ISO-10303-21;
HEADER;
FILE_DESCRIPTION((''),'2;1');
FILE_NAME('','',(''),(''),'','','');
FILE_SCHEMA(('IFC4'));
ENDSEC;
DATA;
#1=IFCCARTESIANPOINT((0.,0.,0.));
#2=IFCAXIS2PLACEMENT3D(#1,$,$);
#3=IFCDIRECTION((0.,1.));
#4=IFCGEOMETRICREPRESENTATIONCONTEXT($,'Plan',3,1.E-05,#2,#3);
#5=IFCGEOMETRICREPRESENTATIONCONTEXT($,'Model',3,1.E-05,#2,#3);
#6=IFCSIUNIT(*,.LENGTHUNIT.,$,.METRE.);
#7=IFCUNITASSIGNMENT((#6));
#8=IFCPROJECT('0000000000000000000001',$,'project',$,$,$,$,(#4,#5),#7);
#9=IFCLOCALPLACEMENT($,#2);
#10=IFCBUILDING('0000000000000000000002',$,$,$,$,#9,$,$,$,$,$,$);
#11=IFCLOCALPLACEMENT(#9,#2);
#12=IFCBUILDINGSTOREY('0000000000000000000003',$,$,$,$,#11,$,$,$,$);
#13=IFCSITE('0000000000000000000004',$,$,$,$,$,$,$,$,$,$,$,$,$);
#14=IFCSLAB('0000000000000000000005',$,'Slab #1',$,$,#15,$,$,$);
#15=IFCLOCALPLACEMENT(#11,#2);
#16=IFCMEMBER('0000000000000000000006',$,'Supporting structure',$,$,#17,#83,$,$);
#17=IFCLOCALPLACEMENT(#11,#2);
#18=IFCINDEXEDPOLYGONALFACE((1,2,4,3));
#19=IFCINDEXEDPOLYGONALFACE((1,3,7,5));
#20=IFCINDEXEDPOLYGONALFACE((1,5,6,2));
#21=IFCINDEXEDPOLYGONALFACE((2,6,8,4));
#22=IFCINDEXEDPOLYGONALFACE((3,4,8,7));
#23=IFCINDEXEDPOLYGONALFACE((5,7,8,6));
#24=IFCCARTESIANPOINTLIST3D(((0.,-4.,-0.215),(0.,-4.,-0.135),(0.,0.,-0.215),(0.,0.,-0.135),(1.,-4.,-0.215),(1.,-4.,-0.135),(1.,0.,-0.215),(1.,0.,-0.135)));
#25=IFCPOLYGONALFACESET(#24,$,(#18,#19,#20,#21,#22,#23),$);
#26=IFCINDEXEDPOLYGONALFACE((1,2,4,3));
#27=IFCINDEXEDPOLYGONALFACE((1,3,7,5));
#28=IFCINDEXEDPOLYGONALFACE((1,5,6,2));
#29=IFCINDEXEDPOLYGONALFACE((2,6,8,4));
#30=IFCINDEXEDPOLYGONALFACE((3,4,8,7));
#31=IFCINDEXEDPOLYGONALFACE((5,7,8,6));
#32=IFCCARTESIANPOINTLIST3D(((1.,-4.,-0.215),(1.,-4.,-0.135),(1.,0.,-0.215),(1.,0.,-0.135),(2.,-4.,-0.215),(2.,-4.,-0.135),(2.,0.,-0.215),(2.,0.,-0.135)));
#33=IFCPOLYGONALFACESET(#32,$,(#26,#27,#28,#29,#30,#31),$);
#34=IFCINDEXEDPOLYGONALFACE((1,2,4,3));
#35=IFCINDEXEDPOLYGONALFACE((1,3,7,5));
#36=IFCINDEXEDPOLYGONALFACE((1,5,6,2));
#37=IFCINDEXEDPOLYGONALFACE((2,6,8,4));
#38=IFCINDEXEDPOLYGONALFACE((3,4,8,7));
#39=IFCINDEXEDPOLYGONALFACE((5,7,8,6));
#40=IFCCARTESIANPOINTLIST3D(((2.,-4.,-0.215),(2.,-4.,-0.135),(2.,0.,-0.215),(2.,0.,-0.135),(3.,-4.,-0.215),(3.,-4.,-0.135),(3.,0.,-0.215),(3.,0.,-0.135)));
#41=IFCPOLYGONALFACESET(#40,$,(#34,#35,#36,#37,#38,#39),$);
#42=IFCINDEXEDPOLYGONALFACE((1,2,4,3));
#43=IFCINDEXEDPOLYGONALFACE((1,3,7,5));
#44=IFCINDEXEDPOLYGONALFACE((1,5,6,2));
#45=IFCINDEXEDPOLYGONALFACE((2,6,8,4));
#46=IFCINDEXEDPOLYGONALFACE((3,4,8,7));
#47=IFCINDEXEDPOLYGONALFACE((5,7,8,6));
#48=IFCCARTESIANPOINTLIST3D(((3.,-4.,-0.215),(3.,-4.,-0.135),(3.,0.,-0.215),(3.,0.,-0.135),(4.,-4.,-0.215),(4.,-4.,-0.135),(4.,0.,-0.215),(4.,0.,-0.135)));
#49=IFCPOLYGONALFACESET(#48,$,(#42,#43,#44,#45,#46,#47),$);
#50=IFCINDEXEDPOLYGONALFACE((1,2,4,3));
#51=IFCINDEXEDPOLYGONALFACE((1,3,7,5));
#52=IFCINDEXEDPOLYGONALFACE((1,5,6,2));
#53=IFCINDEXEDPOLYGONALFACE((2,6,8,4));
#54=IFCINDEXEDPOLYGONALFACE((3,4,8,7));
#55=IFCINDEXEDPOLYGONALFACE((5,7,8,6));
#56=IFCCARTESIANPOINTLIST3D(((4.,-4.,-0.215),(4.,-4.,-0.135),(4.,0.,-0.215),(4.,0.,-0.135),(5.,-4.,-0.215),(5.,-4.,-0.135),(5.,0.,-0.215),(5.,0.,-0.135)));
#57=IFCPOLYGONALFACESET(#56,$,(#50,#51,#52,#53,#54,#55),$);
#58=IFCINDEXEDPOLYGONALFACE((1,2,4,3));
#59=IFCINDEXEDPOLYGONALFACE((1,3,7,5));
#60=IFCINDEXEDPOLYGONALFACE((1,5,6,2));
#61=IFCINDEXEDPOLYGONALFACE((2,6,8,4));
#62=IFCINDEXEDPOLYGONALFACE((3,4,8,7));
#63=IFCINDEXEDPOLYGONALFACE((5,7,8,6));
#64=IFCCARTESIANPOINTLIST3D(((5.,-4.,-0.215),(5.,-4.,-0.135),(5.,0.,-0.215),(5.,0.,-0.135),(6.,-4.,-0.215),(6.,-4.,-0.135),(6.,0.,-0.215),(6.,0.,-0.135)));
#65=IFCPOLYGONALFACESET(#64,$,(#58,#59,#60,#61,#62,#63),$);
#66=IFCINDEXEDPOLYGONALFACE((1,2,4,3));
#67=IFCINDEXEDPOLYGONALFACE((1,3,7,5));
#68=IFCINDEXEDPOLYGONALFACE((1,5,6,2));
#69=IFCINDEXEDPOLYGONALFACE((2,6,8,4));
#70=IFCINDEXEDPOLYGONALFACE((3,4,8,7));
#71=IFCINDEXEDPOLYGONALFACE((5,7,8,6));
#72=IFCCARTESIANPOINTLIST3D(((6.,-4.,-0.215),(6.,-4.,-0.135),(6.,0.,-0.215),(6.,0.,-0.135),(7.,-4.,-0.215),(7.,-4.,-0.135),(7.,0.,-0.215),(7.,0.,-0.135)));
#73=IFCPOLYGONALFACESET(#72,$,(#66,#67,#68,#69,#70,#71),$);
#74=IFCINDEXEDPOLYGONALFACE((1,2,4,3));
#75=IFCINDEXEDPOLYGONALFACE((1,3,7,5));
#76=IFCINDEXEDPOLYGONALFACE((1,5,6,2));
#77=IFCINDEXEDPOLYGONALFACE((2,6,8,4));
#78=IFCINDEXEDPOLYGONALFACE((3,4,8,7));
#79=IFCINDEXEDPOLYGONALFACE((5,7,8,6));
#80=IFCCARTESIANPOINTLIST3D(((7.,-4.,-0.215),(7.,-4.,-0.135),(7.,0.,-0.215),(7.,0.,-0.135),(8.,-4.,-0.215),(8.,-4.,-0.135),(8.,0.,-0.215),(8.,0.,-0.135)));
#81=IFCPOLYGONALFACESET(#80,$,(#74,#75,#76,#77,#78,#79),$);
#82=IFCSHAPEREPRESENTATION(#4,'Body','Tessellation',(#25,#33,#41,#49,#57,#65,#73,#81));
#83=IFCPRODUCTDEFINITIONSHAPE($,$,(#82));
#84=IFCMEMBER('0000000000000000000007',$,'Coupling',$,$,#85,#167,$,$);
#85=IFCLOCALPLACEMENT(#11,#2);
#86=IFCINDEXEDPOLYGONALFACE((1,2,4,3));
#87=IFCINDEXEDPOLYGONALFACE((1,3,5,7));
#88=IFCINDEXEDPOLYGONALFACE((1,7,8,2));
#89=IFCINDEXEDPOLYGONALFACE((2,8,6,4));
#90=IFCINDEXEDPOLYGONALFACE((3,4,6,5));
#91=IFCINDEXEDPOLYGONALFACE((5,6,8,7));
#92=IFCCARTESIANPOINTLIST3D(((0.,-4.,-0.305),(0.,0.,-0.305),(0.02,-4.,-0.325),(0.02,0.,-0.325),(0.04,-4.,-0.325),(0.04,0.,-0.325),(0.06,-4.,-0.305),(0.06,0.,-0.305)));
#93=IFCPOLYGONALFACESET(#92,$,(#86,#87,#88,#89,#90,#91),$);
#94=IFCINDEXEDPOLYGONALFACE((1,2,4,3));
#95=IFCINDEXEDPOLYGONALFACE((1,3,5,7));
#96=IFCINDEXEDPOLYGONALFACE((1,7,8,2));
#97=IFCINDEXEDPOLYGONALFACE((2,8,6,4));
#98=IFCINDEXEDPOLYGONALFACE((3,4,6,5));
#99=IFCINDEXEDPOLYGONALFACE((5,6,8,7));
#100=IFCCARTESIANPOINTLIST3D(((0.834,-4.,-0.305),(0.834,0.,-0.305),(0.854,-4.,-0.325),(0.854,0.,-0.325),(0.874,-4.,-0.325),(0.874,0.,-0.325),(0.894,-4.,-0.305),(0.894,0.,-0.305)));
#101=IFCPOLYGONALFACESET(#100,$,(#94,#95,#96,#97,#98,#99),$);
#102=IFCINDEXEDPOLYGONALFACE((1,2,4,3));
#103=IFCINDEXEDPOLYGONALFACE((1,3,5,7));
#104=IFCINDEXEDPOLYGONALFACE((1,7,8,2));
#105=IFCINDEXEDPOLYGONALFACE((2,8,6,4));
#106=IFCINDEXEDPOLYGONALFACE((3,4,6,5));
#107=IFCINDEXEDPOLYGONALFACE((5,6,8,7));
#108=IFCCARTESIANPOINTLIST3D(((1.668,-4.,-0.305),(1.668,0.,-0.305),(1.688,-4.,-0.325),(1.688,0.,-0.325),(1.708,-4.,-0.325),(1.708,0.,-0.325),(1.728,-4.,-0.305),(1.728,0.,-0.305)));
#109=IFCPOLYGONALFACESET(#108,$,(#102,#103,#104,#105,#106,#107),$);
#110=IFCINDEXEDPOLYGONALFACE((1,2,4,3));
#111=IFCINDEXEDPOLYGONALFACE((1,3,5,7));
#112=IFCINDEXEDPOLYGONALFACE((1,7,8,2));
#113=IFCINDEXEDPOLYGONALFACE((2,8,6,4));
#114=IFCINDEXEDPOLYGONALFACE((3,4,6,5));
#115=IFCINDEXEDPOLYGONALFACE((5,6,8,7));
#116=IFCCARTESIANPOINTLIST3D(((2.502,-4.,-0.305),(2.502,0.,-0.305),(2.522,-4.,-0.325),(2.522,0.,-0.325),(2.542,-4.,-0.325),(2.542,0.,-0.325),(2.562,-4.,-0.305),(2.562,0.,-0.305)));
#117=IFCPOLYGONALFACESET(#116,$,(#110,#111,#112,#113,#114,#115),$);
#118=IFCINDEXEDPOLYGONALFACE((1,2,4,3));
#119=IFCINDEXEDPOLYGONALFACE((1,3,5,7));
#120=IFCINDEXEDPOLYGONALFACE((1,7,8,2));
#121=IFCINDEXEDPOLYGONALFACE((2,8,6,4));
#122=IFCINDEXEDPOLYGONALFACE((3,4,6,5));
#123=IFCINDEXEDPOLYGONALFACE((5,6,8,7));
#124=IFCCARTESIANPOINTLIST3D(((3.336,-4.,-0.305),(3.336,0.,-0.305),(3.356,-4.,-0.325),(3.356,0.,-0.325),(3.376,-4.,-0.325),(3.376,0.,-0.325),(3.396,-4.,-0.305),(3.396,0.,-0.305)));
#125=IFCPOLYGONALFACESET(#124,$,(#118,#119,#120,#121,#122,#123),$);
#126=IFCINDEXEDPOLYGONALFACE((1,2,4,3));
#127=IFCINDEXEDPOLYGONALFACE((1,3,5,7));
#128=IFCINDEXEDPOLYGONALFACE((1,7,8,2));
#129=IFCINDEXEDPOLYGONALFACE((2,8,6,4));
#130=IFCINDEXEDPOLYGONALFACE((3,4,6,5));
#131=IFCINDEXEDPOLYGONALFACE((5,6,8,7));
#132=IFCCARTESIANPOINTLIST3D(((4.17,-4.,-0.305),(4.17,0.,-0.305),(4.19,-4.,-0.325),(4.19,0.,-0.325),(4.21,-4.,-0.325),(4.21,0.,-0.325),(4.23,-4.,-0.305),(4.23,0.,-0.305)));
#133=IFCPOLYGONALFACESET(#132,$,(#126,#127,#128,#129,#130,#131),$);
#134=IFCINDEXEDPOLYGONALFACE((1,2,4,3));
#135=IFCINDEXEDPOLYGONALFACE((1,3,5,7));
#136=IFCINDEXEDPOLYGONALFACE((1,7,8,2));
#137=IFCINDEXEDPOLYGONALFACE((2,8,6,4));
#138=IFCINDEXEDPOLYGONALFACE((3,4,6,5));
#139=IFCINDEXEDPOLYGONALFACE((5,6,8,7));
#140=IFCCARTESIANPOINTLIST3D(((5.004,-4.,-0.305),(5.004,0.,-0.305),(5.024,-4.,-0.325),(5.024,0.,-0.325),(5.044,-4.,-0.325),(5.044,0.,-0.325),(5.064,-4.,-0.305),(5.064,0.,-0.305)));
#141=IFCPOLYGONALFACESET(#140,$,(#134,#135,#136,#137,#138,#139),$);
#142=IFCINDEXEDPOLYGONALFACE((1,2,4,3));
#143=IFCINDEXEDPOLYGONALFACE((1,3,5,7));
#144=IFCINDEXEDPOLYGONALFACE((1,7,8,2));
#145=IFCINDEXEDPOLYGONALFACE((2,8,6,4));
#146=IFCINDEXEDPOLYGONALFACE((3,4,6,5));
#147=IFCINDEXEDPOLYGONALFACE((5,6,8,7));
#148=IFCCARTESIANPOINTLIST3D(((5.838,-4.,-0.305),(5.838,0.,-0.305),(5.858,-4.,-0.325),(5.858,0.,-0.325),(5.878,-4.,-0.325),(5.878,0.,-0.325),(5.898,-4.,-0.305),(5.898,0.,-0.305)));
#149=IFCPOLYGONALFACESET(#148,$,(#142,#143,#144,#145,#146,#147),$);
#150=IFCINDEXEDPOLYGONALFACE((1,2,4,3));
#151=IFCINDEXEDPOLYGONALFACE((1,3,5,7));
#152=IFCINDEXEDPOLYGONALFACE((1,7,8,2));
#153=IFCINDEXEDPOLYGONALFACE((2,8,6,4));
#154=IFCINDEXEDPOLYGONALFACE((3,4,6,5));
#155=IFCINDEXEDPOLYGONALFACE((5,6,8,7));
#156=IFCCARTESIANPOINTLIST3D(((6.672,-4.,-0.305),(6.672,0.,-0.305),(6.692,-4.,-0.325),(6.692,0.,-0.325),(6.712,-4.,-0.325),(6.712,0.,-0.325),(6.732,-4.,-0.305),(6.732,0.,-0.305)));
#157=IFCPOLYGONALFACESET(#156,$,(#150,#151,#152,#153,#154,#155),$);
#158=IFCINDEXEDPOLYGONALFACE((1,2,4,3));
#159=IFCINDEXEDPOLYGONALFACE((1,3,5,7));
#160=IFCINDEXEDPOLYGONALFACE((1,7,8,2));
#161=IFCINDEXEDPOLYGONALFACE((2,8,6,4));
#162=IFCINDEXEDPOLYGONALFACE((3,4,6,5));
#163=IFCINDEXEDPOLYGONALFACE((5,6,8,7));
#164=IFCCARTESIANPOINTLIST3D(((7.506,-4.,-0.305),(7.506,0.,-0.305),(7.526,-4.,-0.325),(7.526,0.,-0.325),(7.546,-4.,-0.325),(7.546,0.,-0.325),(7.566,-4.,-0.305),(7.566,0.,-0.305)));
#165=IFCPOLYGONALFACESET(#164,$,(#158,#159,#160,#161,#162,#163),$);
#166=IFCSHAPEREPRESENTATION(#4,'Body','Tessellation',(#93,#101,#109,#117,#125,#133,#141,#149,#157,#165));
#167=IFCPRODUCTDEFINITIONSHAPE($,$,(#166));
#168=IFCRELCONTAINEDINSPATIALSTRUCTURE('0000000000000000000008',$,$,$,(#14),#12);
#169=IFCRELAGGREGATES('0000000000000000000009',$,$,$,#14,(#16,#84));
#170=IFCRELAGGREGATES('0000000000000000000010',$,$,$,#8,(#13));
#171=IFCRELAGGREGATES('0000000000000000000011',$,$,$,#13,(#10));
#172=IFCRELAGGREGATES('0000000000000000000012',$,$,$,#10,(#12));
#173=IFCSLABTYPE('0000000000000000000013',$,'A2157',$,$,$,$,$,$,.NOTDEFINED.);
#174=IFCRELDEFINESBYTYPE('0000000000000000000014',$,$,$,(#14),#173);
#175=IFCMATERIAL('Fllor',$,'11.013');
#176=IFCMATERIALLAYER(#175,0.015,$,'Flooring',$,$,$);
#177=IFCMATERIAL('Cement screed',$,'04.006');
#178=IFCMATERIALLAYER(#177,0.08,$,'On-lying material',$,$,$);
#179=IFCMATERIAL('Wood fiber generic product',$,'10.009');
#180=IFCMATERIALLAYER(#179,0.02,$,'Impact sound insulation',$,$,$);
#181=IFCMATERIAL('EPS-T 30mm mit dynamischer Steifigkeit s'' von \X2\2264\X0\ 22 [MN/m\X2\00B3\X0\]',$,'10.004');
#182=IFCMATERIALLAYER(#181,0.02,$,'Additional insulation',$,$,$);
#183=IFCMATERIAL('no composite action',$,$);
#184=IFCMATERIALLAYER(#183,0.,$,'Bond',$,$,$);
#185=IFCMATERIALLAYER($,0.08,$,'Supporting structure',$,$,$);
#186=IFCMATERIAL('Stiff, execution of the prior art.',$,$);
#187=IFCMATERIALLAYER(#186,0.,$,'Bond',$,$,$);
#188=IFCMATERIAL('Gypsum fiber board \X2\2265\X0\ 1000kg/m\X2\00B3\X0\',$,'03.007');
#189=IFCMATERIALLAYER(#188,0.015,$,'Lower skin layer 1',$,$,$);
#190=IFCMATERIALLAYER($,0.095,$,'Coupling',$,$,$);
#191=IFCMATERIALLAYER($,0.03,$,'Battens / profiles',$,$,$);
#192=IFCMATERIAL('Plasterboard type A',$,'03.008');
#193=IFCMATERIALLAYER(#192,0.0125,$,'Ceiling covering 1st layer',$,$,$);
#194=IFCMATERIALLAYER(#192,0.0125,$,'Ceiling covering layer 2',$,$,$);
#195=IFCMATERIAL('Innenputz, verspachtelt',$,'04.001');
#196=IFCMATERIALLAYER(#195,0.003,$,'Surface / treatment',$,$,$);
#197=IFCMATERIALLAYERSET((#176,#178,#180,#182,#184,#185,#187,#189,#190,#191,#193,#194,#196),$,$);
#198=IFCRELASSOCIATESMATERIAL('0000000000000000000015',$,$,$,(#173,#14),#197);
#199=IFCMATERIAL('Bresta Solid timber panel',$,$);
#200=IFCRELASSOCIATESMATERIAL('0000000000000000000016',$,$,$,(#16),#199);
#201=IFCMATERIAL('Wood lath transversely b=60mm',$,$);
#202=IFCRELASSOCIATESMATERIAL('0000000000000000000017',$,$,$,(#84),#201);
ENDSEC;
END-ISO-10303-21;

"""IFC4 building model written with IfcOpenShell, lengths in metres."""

from ifc_helpers import new_model, si_unit, direction, frame, frame_2d, origin, place, context, project, spatial, polyline, rectangle, outline, extrude, material, layer, layer_set, type_object, element, aggregate, save


model = new_model("IFC4")

# Units and contexts
plan_context = context("Plan", 3, precision=1e-05, world=origin(), true_north=direction((0.0, 1.0)))
model_context = context("Model", 3, precision=1e-05, world=origin(), true_north=direction((0.0, 1.0)))
ifc_project = project(units=[si_unit("LENGTHUNIT", "METRE")], contexts=[plan_context, model_context])

# Site, building, storey
site = spatial("IfcSite", under=ifc_project)
building_placement = place(None, origin())
building = spatial("IfcBuilding", under=site, at=building_placement)
storey_placement = place(building_placement, origin())
storey = spatial("IfcBuildingStorey", under=building, at=storey_placement)

# Slab, members
ifc_material_1 = material(Name="Fllor", Category="11.013")
ifc_layer_1 = layer(ifc_material_1, 0.015, Name="Flooring")
ifc_material_2 = material(Name="Cement screed", Category="04.006")
ifc_layer_2 = layer(ifc_material_2, 0.08, Name="On-lying material")
ifc_material_3 = material(Name="Wood fiber generic product", Category="10.009")
ifc_layer_3 = layer(ifc_material_3, 0.02, Name="Impact sound insulation")
ifc_material_4 = material(Name="EPS-T 30mm mit dynamischer Steifigkeit s' von ≤ 22 [MN/m³]", Category="10.004")
ifc_layer_4 = layer(ifc_material_4, 0.02, Name="Additional insulation")
ifc_material_5 = material(Name="no composite action")
ifc_layer_5 = layer(ifc_material_5, 0.0, Name="Bond")
ifc_layer_6 = layer(None, 0.08, Name="Supporting structure")
ifc_material_6 = material(Name="Stiff, execution of the prior art.")
ifc_layer_7 = layer(ifc_material_6, 0.0, Name="Bond")
ifc_material_7 = material(Name="Gypsum fiber board ≥ 1000kg/m³", Category="03.007")
ifc_layer_8 = layer(ifc_material_7, 0.015, Name="Lower skin layer 1")
ifc_layer_9 = layer(None, 0.095, Name="Coupling")
ifc_layer_10 = layer(None, 0.03, Name="Battens / profiles")
ifc_material_8 = material(Name="Plasterboard type A", Category="03.008")
ifc_layer_11 = layer(ifc_material_8, 0.0125, Name="Ceiling covering 1st layer")
ifc_layer_12 = layer(ifc_material_8, 0.0125, Name="Ceiling covering layer 2")
ifc_material_9 = material(Name="Innenputz, verspachtelt", Category="04.001")
ifc_layer_13 = layer(ifc_material_9, 0.003, Name="Surface / treatment")
ifc_layer_set = layer_set([ifc_layer_1, ifc_layer_2, ifc_layer_3, ifc_layer_4, ifc_layer_5, ifc_layer_6, ifc_layer_7, ifc_layer_8, ifc_layer_9, ifc_layer_10, ifc_layer_11, ifc_layer_12, ifc_layer_13])
slab_type = type_object("IfcSlabType", Name="A2157", PredefinedType="NOTDEFINED", material=ifc_layer_set)
slab_placement = place(None, frame((0.0, 0.0, 0.0), z_axis=(0.0, 0.0, -1.0), x_axis=(1.0, 0.0, 0.0)))
slab = element("IfcSlab", 1, at=slab_placement, inside=storey, type_object=slab_type, material=ifc_layer_set, Name="Slab #1")
ifc_material_10 = material(Name="Bresta Solid timber panel")
member_1_placement = place(slab_placement, origin())
member_1 = element("IfcMember", 2, at=member_1_placement, material=ifc_material_10, Name="Supporting structure", context=plan_context, shape_type="SweptSolid", body=[
    extrude(rectangle(XDim=1.0, YDim=0.08, at=frame_2d((0.5, 0.04), x_axis=(1.0, 0.0))), frame((0.0, 4.0, 0.135), z_axis=(0.0, -1.0, 0.0), x_axis=(1.0, 0.0, 0.0)), (0.0, 0.0, 1.0), 4.0),
    extrude(rectangle(XDim=1.0, YDim=0.08, at=frame_2d((0.5, 0.04), x_axis=(1.0, 0.0))), frame((1.0, 4.0, 0.135), z_axis=(0.0, -1.0, 0.0), x_axis=(1.0, 0.0, 0.0)), (0.0, 0.0, 1.0), 4.0),
    extrude(rectangle(XDim=1.0, YDim=0.08, at=frame_2d((0.5, 0.04), x_axis=(1.0, 0.0))), frame((2.0, 4.0, 0.135), z_axis=(0.0, -1.0, 0.0), x_axis=(1.0, 0.0, 0.0)), (0.0, 0.0, 1.0), 4.0),
    extrude(rectangle(XDim=1.0, YDim=0.08, at=frame_2d((0.5, 0.04), x_axis=(1.0, 0.0))), frame((3.0, 4.0, 0.135), z_axis=(0.0, -1.0, 0.0), x_axis=(1.0, 0.0, 0.0)), (0.0, 0.0, 1.0), 4.0),
    extrude(rectangle(XDim=1.0, YDim=0.08, at=frame_2d((0.5, 0.04), x_axis=(1.0, 0.0))), frame((4.0, 4.0, 0.135), z_axis=(0.0, -1.0, 0.0), x_axis=(1.0, 0.0, 0.0)), (0.0, 0.0, 1.0), 4.0),
    extrude(rectangle(XDim=1.0, YDim=0.08, at=frame_2d((0.5, 0.04), x_axis=(1.0, 0.0))), frame((5.0, 4.0, 0.135), z_axis=(0.0, -1.0, 0.0), x_axis=(1.0, 0.0, 0.0)), (0.0, 0.0, 1.0), 4.0),
    extrude(rectangle(XDim=1.0, YDim=0.08, at=frame_2d((0.5, 0.04), x_axis=(1.0, 0.0))), frame((6.0, 4.0, 0.135), z_axis=(0.0, -1.0, 0.0), x_axis=(1.0, 0.0, 0.0)), (0.0, 0.0, 1.0), 4.0),
    extrude(rectangle(XDim=1.0, YDim=0.08, at=frame_2d((0.5, 0.04), x_axis=(1.0, 0.0))), frame((7.0, 4.0, 0.135), z_axis=(0.0, -1.0, 0.0), x_axis=(1.0, 0.0, 0.0)), (0.0, 0.0, 1.0), 4.0),
])
ifc_material_11 = material(Name="Wood lath transversely b=60mm")
member_2_placement = place(slab_placement, origin())
member_2 = element("IfcMember", 3, at=member_2_placement, material=ifc_material_11, Name="Coupling", context=plan_context, shape_type="SweptSolid", body=[
    extrude(outline(polyline([(0.0, 0.0), (0.06, 0.0), (0.04, 0.02), (0.02, 0.02), (0.0, 0.0)])), frame((0.0, 4.0, 0.305), z_axis=(0.0, -1.0, 0.0), x_axis=(1.0, 0.0, 0.0)), (0.0, 0.0, 1.0), 4.0),
    extrude(outline(polyline([(0.0, 0.0), (0.06, 0.0), (0.04, 0.02), (0.02, 0.02), (0.0, 0.0)])), frame((0.834, 4.0, 0.305), z_axis=(0.0, -1.0, 0.0), x_axis=(1.0, 0.0, 0.0)), (0.0, 0.0, 1.0), 4.0),
    extrude(outline(polyline([(0.0, 0.0), (0.06, 0.0), (0.04, 0.02), (0.02, 0.02), (0.0, 0.0)])), frame((1.668, 4.0, 0.305), z_axis=(0.0, -1.0, 0.0), x_axis=(1.0, 0.0, 0.0)), (0.0, 0.0, 1.0), 4.0),
    extrude(outline(polyline([(0.0, 0.0), (0.06, 0.0), (0.04, 0.02), (0.02, 0.02), (0.0, 0.0)])), frame((2.502, 4.0, 0.305), z_axis=(0.0, -1.0, 0.0), x_axis=(1.0, 0.0, 0.0)), (0.0, 0.0, 1.0), 4.0),
    extrude(outline(polyline([(0.0, 0.0), (0.06, 0.0), (0.04, 0.02), (0.02, 0.02), (0.0, 0.0)])), frame((3.336, 4.0, 0.305), z_axis=(0.0, -1.0, 0.0), x_axis=(1.0, 0.0, 0.0)), (0.0, 0.0, 1.0), 4.0),
    extrude(outline(polyline([(0.0, 0.0), (0.06, 0.0), (0.04, 0.02), (0.02, 0.02), (0.0, 0.0)])), frame((4.17, 4.0, 0.305), z_axis=(0.0, -1.0, 0.0), x_axis=(1.0, 0.0, 0.0)), (0.0, 0.0, 1.0), 4.0),
    extrude(outline(polyline([(0.0, 0.0), (0.06, 0.0), (0.04, 0.02), (0.02, 0.02), (0.0, 0.0)])), frame((5.004, 4.0, 0.305), z_axis=(0.0, -1.0, 0.0), x_axis=(1.0, 0.0, 0.0)), (0.0, 0.0, 1.0), 4.0),
    extrude(outline(polyline([(0.0, 0.0), (0.06, 0.0), (0.04, 0.02), (0.02, 0.02), (0.0, 0.0)])), frame((5.838, 4.0, 0.305), z_axis=(0.0, -1.0, 0.0), x_axis=(1.0, 0.0, 0.0)), (0.0, 0.0, 1.0), 4.0),
    extrude(outline(polyline([(0.0, 0.0), (0.06, 0.0), (0.04, 0.02), (0.02, 0.02), (0.0, 0.0)])), frame((6.672, 4.0, 0.305), z_axis=(0.0, -1.0, 0.0), x_axis=(1.0, 0.0, 0.0)), (0.0, 0.0, 1.0), 4.0),
    extrude(outline(polyline([(0.0, 0.0), (0.06, 0.0), (0.04, 0.02), (0.02, 0.02), (0.0, 0.0)])), frame((7.506, 4.0, 0.305), z_axis=(0.0, -1.0, 0.0), x_axis=(1.0, 0.0, 0.0)), (0.0, 0.0, 1.0), 4.0),
])
aggregate(slab, [member_1, member_2])

save(model, "model.ifc")
